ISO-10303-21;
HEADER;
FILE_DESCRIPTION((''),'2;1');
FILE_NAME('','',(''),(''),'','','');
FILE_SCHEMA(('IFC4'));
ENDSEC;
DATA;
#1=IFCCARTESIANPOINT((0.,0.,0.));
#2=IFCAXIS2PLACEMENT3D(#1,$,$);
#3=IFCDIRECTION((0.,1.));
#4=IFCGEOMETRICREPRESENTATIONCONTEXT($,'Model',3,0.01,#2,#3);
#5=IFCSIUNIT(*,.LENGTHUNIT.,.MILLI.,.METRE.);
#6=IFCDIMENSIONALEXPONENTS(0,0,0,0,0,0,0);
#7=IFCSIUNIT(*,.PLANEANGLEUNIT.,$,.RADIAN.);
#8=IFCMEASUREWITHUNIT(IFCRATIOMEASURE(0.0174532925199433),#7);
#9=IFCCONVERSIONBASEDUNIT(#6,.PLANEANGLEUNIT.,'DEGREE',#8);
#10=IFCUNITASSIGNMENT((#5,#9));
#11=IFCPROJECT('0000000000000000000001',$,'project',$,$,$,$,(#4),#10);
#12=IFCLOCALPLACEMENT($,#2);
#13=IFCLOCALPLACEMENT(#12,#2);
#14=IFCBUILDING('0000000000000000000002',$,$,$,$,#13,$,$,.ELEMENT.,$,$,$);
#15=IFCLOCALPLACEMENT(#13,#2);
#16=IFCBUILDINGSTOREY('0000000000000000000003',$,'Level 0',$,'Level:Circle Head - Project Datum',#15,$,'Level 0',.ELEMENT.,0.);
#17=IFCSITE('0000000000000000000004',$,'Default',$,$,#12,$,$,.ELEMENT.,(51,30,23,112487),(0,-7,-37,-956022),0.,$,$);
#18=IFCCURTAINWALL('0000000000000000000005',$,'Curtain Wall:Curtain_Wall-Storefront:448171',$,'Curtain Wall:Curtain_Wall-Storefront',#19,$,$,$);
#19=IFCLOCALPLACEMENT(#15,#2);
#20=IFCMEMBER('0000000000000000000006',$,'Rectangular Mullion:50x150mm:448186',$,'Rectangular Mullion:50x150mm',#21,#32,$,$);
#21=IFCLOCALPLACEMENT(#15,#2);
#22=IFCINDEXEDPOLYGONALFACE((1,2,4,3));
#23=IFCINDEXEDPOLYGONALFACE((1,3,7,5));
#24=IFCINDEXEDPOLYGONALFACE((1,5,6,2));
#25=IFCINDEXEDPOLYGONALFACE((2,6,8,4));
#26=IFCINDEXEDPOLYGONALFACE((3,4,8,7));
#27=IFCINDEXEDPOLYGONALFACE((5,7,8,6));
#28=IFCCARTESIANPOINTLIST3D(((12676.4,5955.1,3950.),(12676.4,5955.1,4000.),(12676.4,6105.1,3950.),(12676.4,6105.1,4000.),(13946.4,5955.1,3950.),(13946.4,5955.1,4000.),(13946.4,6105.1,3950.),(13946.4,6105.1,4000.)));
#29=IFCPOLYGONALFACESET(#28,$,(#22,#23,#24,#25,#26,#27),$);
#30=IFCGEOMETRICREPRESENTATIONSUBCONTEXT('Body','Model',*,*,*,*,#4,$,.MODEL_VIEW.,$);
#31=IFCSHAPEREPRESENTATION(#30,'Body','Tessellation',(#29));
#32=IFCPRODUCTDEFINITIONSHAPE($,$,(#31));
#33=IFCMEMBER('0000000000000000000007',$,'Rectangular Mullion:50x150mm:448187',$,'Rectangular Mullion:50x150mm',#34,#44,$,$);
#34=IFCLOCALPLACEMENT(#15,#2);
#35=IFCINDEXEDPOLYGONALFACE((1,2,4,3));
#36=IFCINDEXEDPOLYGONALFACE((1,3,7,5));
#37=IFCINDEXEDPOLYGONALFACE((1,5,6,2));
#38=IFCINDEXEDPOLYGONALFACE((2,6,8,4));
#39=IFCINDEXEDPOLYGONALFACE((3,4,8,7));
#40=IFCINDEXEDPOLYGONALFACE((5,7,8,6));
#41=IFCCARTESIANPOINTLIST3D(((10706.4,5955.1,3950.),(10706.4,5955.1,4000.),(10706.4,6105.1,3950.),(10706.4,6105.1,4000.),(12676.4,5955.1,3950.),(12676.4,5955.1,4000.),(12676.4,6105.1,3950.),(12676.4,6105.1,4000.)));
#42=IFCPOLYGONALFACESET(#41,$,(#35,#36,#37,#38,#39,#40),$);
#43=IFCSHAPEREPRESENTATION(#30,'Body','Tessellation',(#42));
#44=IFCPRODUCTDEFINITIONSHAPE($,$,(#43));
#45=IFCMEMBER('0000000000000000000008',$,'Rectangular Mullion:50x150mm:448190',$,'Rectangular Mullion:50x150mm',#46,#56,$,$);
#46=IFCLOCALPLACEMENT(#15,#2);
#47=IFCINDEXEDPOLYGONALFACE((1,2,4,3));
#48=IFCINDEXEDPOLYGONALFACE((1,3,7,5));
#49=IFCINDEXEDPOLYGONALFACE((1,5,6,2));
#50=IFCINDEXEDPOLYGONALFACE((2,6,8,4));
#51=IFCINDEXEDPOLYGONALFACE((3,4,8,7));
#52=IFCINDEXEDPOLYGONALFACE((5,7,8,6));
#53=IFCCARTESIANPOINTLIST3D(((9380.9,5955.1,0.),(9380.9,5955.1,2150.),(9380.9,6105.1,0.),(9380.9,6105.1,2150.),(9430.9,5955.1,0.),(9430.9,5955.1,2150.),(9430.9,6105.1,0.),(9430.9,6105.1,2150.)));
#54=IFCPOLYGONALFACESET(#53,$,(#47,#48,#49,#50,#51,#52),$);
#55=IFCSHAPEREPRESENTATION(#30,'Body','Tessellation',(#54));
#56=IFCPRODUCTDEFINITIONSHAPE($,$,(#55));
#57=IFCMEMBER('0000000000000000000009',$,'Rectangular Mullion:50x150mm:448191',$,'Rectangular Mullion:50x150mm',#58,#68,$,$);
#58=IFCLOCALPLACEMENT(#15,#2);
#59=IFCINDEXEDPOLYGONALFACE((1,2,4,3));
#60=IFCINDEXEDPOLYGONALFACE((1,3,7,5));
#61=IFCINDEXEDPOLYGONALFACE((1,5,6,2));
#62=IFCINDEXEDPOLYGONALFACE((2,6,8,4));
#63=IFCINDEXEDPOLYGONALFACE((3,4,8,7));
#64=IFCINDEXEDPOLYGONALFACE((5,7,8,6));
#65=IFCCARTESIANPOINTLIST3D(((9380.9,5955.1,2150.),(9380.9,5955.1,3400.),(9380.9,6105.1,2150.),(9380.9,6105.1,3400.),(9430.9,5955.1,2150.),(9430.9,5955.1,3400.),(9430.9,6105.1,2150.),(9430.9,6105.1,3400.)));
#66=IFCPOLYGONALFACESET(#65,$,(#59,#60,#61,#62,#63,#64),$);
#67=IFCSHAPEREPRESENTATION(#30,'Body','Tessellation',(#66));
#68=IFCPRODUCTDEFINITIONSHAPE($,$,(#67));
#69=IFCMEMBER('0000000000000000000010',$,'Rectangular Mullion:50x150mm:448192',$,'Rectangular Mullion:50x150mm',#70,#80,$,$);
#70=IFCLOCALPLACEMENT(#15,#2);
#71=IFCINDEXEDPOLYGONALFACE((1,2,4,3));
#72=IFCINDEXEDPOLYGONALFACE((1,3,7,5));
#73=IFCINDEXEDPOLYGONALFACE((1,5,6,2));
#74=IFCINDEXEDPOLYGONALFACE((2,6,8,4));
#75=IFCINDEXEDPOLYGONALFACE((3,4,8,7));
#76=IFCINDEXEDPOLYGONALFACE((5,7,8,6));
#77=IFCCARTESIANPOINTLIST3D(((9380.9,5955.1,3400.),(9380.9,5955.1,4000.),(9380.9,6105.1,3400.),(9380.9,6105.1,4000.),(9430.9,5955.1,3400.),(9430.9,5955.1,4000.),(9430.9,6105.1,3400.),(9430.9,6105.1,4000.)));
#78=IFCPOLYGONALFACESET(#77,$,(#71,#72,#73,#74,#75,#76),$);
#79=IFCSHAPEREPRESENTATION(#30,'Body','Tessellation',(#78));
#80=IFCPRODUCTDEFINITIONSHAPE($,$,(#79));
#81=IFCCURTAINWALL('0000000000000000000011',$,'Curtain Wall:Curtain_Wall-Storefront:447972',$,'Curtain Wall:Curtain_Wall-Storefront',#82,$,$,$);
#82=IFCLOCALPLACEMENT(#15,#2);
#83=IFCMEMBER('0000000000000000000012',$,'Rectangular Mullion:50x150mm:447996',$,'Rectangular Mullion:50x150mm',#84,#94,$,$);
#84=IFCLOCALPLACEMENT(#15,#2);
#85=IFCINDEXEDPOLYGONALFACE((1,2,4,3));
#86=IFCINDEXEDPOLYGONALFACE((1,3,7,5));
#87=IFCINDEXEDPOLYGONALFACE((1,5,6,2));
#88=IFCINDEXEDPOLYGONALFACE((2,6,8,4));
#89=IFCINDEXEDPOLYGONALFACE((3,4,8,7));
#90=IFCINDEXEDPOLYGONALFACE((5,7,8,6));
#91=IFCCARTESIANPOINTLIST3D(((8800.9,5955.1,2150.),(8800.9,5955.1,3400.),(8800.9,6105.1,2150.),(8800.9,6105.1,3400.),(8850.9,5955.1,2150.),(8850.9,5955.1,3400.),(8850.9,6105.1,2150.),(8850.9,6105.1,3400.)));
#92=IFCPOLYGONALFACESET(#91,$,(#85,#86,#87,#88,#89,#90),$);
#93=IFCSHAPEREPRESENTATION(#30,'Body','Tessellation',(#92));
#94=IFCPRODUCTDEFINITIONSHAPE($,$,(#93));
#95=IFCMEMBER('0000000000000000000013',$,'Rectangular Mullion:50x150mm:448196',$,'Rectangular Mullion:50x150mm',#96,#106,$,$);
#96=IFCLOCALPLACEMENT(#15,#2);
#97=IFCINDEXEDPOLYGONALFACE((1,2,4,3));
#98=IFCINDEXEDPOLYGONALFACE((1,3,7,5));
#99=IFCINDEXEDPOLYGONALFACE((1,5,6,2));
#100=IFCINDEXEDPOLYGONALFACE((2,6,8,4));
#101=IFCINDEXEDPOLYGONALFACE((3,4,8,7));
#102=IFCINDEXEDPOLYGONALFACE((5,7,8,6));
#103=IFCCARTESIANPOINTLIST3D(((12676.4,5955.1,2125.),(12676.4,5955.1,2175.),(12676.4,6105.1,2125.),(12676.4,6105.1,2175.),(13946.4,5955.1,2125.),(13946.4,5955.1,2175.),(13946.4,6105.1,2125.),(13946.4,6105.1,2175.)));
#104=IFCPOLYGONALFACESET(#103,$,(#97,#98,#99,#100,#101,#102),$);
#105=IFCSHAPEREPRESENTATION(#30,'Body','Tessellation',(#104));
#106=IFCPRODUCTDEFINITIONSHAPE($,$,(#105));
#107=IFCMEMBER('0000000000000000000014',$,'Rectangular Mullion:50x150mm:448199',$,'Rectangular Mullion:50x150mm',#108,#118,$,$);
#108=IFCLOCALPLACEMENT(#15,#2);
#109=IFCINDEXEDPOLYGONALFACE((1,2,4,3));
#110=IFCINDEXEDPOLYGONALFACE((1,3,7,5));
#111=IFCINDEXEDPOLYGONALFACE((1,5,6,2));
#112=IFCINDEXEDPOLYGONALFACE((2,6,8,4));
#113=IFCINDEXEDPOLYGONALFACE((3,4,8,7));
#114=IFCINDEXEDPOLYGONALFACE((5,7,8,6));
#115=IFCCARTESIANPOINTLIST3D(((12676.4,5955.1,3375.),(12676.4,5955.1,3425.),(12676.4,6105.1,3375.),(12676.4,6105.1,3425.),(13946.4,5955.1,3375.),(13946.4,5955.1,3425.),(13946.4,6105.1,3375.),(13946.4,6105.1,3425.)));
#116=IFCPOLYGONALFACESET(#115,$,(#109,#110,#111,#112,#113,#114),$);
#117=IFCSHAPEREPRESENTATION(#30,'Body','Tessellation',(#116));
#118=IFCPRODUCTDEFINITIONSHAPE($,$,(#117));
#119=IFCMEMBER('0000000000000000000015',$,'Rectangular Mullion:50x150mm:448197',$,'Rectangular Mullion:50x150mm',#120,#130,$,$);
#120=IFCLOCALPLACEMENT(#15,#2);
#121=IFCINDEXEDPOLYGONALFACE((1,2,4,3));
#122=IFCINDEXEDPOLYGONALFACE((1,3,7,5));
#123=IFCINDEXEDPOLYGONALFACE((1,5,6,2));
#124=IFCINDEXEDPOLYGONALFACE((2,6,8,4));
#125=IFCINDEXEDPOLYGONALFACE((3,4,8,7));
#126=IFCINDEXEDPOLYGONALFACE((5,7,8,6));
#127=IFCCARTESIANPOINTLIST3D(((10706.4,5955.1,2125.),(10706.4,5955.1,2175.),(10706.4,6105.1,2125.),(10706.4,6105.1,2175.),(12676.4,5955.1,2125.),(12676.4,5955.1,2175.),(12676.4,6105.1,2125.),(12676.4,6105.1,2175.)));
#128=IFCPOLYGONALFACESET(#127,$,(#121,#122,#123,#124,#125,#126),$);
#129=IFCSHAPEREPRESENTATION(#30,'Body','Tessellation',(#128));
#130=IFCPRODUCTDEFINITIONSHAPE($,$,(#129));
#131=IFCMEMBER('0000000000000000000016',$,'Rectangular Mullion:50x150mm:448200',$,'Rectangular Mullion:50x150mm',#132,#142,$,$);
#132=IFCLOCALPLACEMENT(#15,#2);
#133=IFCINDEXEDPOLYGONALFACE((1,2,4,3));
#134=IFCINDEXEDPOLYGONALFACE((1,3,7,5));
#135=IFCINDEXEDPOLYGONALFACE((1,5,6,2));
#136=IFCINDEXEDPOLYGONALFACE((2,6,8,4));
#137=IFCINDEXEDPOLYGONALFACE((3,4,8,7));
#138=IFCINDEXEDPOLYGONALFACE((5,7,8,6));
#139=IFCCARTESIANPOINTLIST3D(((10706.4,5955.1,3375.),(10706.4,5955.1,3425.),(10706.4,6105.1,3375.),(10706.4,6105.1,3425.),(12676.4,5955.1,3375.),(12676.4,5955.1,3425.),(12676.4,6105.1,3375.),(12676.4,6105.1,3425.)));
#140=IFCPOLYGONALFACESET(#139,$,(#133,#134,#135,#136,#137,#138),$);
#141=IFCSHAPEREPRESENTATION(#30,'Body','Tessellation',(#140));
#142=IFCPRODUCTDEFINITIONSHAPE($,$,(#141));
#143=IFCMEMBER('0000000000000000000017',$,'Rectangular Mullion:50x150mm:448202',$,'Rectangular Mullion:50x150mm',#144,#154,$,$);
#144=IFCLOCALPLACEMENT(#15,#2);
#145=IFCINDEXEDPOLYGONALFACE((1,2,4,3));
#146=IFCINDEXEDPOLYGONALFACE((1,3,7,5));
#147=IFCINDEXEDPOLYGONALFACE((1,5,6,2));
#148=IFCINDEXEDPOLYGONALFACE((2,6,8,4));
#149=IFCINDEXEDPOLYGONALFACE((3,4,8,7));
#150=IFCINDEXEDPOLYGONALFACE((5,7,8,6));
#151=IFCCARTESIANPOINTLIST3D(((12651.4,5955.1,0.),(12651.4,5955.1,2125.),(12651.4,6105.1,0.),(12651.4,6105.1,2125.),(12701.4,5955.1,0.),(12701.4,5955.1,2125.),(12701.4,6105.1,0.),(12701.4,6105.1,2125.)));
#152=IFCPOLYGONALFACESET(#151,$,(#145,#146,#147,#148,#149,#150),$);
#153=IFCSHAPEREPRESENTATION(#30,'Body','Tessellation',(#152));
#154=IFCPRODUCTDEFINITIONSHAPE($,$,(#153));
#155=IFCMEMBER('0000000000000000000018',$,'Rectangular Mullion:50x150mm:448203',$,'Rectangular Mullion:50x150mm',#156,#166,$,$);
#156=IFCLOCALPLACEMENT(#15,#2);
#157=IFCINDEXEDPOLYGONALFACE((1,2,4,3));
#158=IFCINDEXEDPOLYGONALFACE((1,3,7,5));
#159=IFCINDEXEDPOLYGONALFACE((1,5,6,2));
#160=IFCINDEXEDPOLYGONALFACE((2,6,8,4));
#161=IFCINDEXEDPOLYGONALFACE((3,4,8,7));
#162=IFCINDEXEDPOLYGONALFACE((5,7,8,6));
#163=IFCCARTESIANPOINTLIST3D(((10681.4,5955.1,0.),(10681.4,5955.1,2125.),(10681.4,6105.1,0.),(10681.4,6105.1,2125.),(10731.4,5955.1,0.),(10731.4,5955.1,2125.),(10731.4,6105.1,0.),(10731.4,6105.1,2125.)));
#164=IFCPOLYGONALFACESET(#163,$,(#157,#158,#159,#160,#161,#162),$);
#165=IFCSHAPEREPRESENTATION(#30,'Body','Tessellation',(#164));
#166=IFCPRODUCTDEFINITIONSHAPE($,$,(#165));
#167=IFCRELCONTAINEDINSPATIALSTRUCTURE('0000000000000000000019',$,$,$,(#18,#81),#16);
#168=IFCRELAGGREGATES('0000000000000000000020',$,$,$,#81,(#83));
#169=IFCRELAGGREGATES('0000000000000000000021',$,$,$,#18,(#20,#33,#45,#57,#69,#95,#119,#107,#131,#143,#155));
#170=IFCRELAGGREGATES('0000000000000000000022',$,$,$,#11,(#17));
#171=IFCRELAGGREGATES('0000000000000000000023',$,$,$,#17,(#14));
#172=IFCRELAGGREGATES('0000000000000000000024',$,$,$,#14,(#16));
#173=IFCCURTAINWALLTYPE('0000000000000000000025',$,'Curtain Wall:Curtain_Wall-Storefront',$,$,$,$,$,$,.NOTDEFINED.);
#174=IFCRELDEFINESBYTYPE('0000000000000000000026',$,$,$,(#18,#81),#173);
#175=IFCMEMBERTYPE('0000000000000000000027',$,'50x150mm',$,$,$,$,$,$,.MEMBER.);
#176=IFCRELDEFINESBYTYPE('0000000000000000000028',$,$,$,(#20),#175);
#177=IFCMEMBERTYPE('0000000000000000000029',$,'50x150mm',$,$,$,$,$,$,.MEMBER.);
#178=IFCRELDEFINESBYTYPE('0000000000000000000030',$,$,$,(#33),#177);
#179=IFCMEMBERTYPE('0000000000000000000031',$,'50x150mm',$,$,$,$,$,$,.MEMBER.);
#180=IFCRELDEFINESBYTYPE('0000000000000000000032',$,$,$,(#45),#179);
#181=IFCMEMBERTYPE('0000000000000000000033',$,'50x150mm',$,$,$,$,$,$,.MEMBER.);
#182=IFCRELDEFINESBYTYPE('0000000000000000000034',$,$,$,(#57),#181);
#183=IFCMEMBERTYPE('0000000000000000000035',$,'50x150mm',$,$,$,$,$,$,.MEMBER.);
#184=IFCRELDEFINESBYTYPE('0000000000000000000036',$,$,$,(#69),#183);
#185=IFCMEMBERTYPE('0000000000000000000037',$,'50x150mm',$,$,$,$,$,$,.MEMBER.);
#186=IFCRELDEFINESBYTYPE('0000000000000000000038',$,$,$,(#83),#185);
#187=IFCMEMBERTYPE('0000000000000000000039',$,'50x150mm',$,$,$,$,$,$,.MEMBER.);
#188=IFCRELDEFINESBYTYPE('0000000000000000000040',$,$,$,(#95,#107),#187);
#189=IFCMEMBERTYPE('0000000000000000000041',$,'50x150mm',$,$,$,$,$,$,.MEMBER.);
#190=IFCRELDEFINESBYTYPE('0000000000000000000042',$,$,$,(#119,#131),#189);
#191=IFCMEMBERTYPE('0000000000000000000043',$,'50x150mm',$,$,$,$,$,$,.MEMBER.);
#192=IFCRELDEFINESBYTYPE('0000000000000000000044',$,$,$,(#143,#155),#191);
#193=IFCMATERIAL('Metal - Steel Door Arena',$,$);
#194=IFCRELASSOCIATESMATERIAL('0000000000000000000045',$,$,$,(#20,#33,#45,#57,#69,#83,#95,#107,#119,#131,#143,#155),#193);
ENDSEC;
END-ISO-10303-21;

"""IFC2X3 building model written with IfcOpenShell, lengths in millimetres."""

from ifc_helpers import new_model, entity, si_unit, converted_unit, direction, frame, origin, origin_2d_with_axis, place, context, subcontext, project, spatial, rectangle, extrude, source, transform, mapped, material, type_object, type_shapes, element, aggregate, save


model = new_model("IFC2X3")

# Units and contexts
model_context = context("Model", 3, precision=0.01, world=origin(), true_north=direction((0.0, 1.0)))
body_context = subcontext(model_context, "Body", "Model", "MODEL_VIEW")
ifc_project = project(units=[si_unit("LENGTHUNIT", "METRE", prefix="MILLI"), converted_unit("PLANEANGLEUNIT", "DEGREE", entity("IfcRatioMeasure", 0.0174532925199433), si_unit("PLANEANGLEUNIT", "RADIAN"), dimensions=[0, 0, 0, 0, 0, 0, 0])], contexts=[model_context])

# Site, building, storey
site_placement = place(None, origin())
site = spatial("IfcSite", under=ifc_project, at=site_placement, Name="Default", CompositionType="ELEMENT", RefLatitude=(51, 30, 23, 112487), RefLongitude=(0, -7, -37, -956022), RefElevation=0.0)
building_placement = place(site_placement, origin())
building = spatial("IfcBuilding", under=site, at=building_placement, CompositionType="ELEMENT")
storey_placement = place(building_placement, origin())
storey = spatial("IfcBuildingStorey", under=building, at=storey_placement, Name="Level 0", ObjectType="Level:Circle Head - Project Datum", LongName="Level 0", CompositionType="ELEMENT", Elevation=0.0)

# Curtain wall, members
curtain_wall_type = type_object("IfcCurtainWallType", Name="Curtain Wall:Curtain_Wall-Storefront", PredefinedType="NOTDEFINED")
curtain_wall_1_placement = place(storey_placement, origin())
curtain_wall_1 = element("IfcCurtainWall", 1, at=curtain_wall_1_placement, inside=storey, type_object=curtain_wall_type, Name="Curtain Wall:Curtain_Wall-Storefront:448171", ObjectType="Curtain Wall:Curtain_Wall-Storefront")
ifc_material_1 = material(Name="Metal - Steel Door Arena")
member_type_1 = type_object("IfcMemberType", Name="50x150mm", PredefinedType="MEMBER")
shared_shape_1 = source(origin(), body_context, "Body", "SweptSolid", [
    extrude(rectangle(XDim=150.0, YDim=50.0, at=origin_2d_with_axis()), frame((-25.0, 0.0, -1270.0), z_axis=(0.0, 0.0, 1.0), x_axis=(0.0, -1.0, 0.0)), (0.0, 0.0, 1.0), 1270.0),
])
type_shapes(member_type_1, [shared_shape_1])
member_1_placement = place(storey_placement, frame((12676.4, 6030.1, 4000.0), z_axis=(-1.0, 0.0, 0.0), x_axis=(0.0, 0.0, 1.0)))
member_1 = element("IfcMember", 2, at=member_1_placement, type_object=member_type_1, material=ifc_material_1, Name="Rectangular Mullion:50x150mm:448186", ObjectType="Rectangular Mullion:50x150mm", context=body_context, shape_type="MappedRepresentation", body=[
    mapped(shared_shape_1, transform((0.0, 0.0, 0.0), scale=1.0)),
])
member_type_2 = type_object("IfcMemberType", Name="50x150mm", PredefinedType="MEMBER")
shared_shape_2 = source(origin(), body_context, "Body", "SweptSolid", [
    extrude(rectangle(XDim=150.0, YDim=50.0, at=origin_2d_with_axis()), frame((-25.0, 0.0, -1970.0), z_axis=(0.0, 0.0, 1.0), x_axis=(0.0, -1.0, 0.0)), (0.0, 0.0, 1.0), 1970.0),
])
type_shapes(member_type_2, [shared_shape_2])
member_2_placement = place(storey_placement, frame((10706.4, 6030.1, 4000.0), z_axis=(-1.0, 0.0, 0.0), x_axis=(0.0, 0.0, 1.0)))
member_2 = element("IfcMember", 3, at=member_2_placement, type_object=member_type_2, material=ifc_material_1, Name="Rectangular Mullion:50x150mm:448187", ObjectType="Rectangular Mullion:50x150mm", context=body_context, shape_type="MappedRepresentation", body=[
    mapped(shared_shape_2, transform((0.0, 0.0, 0.0), scale=1.0)),
])
member_type_3 = type_object("IfcMemberType", Name="50x150mm", PredefinedType="MEMBER")
shared_shape_3 = source(origin(), body_context, "Body", "SweptSolid", [
    extrude(rectangle(XDim=150.0, YDim=50.0, at=origin_2d_with_axis()), frame((-25.0, 0.0, -2150.0), z_axis=(0.0, 0.0, 1.0), x_axis=(0.0, -1.0, 0.0)), (0.0, 0.0, 1.0), 2150.0),
])
type_shapes(member_type_3, [shared_shape_3])
member_3_placement = place(storey_placement, frame((9380.9, 6030.1, 0.0), z_axis=(0.0, 0.0, -1.0), x_axis=(-1.0, 0.0, 0.0)))
member_3 = element("IfcMember", 4, at=member_3_placement, type_object=member_type_3, material=ifc_material_1, Name="Rectangular Mullion:50x150mm:448190", ObjectType="Rectangular Mullion:50x150mm", context=body_context, shape_type="MappedRepresentation", body=[
    mapped(shared_shape_3, transform((0.0, 0.0, 0.0), scale=1.0)),
])
member_type_4 = type_object("IfcMemberType", Name="50x150mm", PredefinedType="MEMBER")
shared_shape_4 = source(origin(), body_context, "Body", "SweptSolid", [
    extrude(rectangle(XDim=150.0, YDim=50.0, at=origin_2d_with_axis()), frame((-25.0, 0.0, -1250.0), z_axis=(0.0, 0.0, 1.0), x_axis=(0.0, -1.0, 0.0)), (0.0, 0.0, 1.0), 1250.0),
])
type_shapes(member_type_4, [shared_shape_4])
member_4_placement = place(storey_placement, frame((9380.9, 6030.1, 2150.0), z_axis=(0.0, 0.0, -1.0), x_axis=(-1.0, 0.0, 0.0)))
member_4 = element("IfcMember", 5, at=member_4_placement, type_object=member_type_4, material=ifc_material_1, Name="Rectangular Mullion:50x150mm:448191", ObjectType="Rectangular Mullion:50x150mm", context=body_context, shape_type="MappedRepresentation", body=[
    mapped(shared_shape_4, transform((0.0, 0.0, 0.0), scale=1.0)),
])
member_type_5 = type_object("IfcMemberType", Name="50x150mm", PredefinedType="MEMBER")
shared_shape_5 = source(origin(), body_context, "Body", "SweptSolid", [
    extrude(rectangle(XDim=150.0, YDim=50.0, at=origin_2d_with_axis()), frame((-25.0, 0.0, -600.0), z_axis=(0.0, 0.0, 1.0), x_axis=(0.0, -1.0, 0.0)), (0.0, 0.0, 1.0), 600.0),
])
type_shapes(member_type_5, [shared_shape_5])
member_5_placement = place(storey_placement, frame((9380.9, 6030.1, 3400.0), z_axis=(0.0, 0.0, -1.0), x_axis=(-1.0, 0.0, 0.0)))
member_5 = element("IfcMember", 6, at=member_5_placement, type_object=member_type_5, material=ifc_material_1, Name="Rectangular Mullion:50x150mm:448192", ObjectType="Rectangular Mullion:50x150mm", context=body_context, shape_type="MappedRepresentation", body=[
    mapped(shared_shape_5, transform((0.0, 0.0, 0.0), scale=1.0)),
])

# Curtain wall, member
curtain_wall_2_placement = place(storey_placement, origin())
curtain_wall_2 = element("IfcCurtainWall", 7, at=curtain_wall_2_placement, inside=storey, type_object=curtain_wall_type, Name="Curtain Wall:Curtain_Wall-Storefront:447972", ObjectType="Curtain Wall:Curtain_Wall-Storefront")
member_type_6 = type_object("IfcMemberType", Name="50x150mm", PredefinedType="MEMBER")
shared_shape_6 = source(origin(), body_context, "Body", "SweptSolid", [
    extrude(rectangle(XDim=150.0, YDim=50.0, at=origin_2d_with_axis()), frame((-25.0, 0.0, -1250.0), z_axis=(0.0, 0.0, 1.0), x_axis=(0.0, -1.0, 0.0)), (0.0, 0.0, 1.0), 1250.0),
])
type_shapes(member_type_6, [shared_shape_6])
member_6_placement = place(storey_placement, frame((8850.9, 6030.1, 3400.0)))
member_6 = element("IfcMember", 8, at=member_6_placement, type_object=member_type_6, material=ifc_material_1, Name="Rectangular Mullion:50x150mm:447996", ObjectType="Rectangular Mullion:50x150mm", context=body_context, shape_type="MappedRepresentation", body=[
    mapped(shared_shape_6, transform((0.0, 0.0, 0.0), scale=1.0)),
])
aggregate(curtain_wall_2, [member_6])

# Members
member_type_7 = type_object("IfcMemberType", Name="50x150mm", PredefinedType="MEMBER")
shared_shape_7 = source(origin(), body_context, "Body", "SweptSolid", [
    extrude(rectangle(XDim=150.0, YDim=50.0, at=origin_2d_with_axis()), frame((0.0, 0.0, -1270.0), z_axis=(0.0, 0.0, 1.0), x_axis=(0.0, -1.0, 0.0)), (0.0, 0.0, 1.0), 1270.0),
])
type_shapes(member_type_7, [shared_shape_7])
member_7_placement = place(storey_placement, frame((12676.4, 6030.1, 2150.0), z_axis=(-1.0, 0.0, 0.0), x_axis=(0.0, 0.0, 1.0)))
member_7 = element("IfcMember", 9, at=member_7_placement, type_object=member_type_7, material=ifc_material_1, Name="Rectangular Mullion:50x150mm:448196", ObjectType="Rectangular Mullion:50x150mm", context=body_context, shape_type="MappedRepresentation", body=[
    mapped(shared_shape_7, transform((0.0, 0.0, 0.0), scale=1.0)),
])
member_8_placement = place(storey_placement, frame((12676.4, 6030.1, 3400.0), z_axis=(-1.0, 0.0, 0.0), x_axis=(0.0, 0.0, 1.0)))
member_8 = element("IfcMember", 10, at=member_8_placement, type_object=member_type_7, material=ifc_material_1, Name="Rectangular Mullion:50x150mm:448199", ObjectType="Rectangular Mullion:50x150mm", context=body_context, shape_type="MappedRepresentation", body=[
    mapped(shared_shape_7, transform((0.0, 0.0, 0.0), scale=1.0)),
])
member_type_8 = type_object("IfcMemberType", Name="50x150mm", PredefinedType="MEMBER")
shared_shape_8 = source(origin(), body_context, "Body", "SweptSolid", [
    extrude(rectangle(XDim=150.0, YDim=50.0, at=origin_2d_with_axis()), frame((0.0, 0.0, -1970.0), z_axis=(0.0, 0.0, 1.0), x_axis=(0.0, -1.0, 0.0)), (0.0, 0.0, 1.0), 1970.0),
])
type_shapes(member_type_8, [shared_shape_8])
member_9_placement = place(storey_placement, frame((10706.4, 6030.1, 2150.0), z_axis=(-1.0, 0.0, 0.0), x_axis=(0.0, 0.0, 1.0)))
member_9 = element("IfcMember", 11, at=member_9_placement, type_object=member_type_8, material=ifc_material_1, Name="Rectangular Mullion:50x150mm:448197", ObjectType="Rectangular Mullion:50x150mm", context=body_context, shape_type="MappedRepresentation", body=[
    mapped(shared_shape_8, transform((0.0, 0.0, 0.0), scale=1.0)),
])
member_10_placement = place(storey_placement, frame((10706.4, 6030.1, 3400.0), z_axis=(-1.0, 0.0, 0.0), x_axis=(0.0, 0.0, 1.0)))
member_10 = element("IfcMember", 12, at=member_10_placement, type_object=member_type_8, material=ifc_material_1, Name="Rectangular Mullion:50x150mm:448200", ObjectType="Rectangular Mullion:50x150mm", context=body_context, shape_type="MappedRepresentation", body=[
    mapped(shared_shape_8, transform((0.0, 0.0, 0.0), scale=1.0)),
])
member_type_9 = type_object("IfcMemberType", Name="50x150mm", PredefinedType="MEMBER")
shared_shape_9 = source(origin(), body_context, "Body", "SweptSolid", [
    extrude(rectangle(XDim=150.0, YDim=50.0, at=origin_2d_with_axis()), frame((0.0, 0.0, -2125.0), z_axis=(0.0, 0.0, 1.0), x_axis=(0.0, -1.0, 0.0)), (0.0, 0.0, 1.0), 2125.0),
])
type_shapes(member_type_9, [shared_shape_9])
member_11_placement = place(storey_placement, frame((12676.4, 6030.1, 0.0), z_axis=(0.0, 0.0, -1.0), x_axis=(-1.0, 0.0, 0.0)))
member_11 = element("IfcMember", 13, at=member_11_placement, type_object=member_type_9, material=ifc_material_1, Name="Rectangular Mullion:50x150mm:448202", ObjectType="Rectangular Mullion:50x150mm", context=body_context, shape_type="MappedRepresentation", body=[
    mapped(shared_shape_9, transform((0.0, 0.0, 0.0), scale=1.0)),
])
member_12_placement = place(storey_placement, frame((10706.4, 6030.1, 0.0), z_axis=(0.0, 0.0, -1.0), x_axis=(-1.0, 0.0, 0.0)))
member_12 = element("IfcMember", 14, at=member_12_placement, type_object=member_type_9, material=ifc_material_1, Name="Rectangular Mullion:50x150mm:448203", ObjectType="Rectangular Mullion:50x150mm", context=body_context, shape_type="MappedRepresentation", body=[
    mapped(shared_shape_9, transform((0.0, 0.0, 0.0), scale=1.0)),
])

aggregate(curtain_wall_1, [member_1, member_2, member_3, member_4, member_5, member_7, member_9, member_8, member_10, member_11, member_12])

save(model, "model.ifc")
